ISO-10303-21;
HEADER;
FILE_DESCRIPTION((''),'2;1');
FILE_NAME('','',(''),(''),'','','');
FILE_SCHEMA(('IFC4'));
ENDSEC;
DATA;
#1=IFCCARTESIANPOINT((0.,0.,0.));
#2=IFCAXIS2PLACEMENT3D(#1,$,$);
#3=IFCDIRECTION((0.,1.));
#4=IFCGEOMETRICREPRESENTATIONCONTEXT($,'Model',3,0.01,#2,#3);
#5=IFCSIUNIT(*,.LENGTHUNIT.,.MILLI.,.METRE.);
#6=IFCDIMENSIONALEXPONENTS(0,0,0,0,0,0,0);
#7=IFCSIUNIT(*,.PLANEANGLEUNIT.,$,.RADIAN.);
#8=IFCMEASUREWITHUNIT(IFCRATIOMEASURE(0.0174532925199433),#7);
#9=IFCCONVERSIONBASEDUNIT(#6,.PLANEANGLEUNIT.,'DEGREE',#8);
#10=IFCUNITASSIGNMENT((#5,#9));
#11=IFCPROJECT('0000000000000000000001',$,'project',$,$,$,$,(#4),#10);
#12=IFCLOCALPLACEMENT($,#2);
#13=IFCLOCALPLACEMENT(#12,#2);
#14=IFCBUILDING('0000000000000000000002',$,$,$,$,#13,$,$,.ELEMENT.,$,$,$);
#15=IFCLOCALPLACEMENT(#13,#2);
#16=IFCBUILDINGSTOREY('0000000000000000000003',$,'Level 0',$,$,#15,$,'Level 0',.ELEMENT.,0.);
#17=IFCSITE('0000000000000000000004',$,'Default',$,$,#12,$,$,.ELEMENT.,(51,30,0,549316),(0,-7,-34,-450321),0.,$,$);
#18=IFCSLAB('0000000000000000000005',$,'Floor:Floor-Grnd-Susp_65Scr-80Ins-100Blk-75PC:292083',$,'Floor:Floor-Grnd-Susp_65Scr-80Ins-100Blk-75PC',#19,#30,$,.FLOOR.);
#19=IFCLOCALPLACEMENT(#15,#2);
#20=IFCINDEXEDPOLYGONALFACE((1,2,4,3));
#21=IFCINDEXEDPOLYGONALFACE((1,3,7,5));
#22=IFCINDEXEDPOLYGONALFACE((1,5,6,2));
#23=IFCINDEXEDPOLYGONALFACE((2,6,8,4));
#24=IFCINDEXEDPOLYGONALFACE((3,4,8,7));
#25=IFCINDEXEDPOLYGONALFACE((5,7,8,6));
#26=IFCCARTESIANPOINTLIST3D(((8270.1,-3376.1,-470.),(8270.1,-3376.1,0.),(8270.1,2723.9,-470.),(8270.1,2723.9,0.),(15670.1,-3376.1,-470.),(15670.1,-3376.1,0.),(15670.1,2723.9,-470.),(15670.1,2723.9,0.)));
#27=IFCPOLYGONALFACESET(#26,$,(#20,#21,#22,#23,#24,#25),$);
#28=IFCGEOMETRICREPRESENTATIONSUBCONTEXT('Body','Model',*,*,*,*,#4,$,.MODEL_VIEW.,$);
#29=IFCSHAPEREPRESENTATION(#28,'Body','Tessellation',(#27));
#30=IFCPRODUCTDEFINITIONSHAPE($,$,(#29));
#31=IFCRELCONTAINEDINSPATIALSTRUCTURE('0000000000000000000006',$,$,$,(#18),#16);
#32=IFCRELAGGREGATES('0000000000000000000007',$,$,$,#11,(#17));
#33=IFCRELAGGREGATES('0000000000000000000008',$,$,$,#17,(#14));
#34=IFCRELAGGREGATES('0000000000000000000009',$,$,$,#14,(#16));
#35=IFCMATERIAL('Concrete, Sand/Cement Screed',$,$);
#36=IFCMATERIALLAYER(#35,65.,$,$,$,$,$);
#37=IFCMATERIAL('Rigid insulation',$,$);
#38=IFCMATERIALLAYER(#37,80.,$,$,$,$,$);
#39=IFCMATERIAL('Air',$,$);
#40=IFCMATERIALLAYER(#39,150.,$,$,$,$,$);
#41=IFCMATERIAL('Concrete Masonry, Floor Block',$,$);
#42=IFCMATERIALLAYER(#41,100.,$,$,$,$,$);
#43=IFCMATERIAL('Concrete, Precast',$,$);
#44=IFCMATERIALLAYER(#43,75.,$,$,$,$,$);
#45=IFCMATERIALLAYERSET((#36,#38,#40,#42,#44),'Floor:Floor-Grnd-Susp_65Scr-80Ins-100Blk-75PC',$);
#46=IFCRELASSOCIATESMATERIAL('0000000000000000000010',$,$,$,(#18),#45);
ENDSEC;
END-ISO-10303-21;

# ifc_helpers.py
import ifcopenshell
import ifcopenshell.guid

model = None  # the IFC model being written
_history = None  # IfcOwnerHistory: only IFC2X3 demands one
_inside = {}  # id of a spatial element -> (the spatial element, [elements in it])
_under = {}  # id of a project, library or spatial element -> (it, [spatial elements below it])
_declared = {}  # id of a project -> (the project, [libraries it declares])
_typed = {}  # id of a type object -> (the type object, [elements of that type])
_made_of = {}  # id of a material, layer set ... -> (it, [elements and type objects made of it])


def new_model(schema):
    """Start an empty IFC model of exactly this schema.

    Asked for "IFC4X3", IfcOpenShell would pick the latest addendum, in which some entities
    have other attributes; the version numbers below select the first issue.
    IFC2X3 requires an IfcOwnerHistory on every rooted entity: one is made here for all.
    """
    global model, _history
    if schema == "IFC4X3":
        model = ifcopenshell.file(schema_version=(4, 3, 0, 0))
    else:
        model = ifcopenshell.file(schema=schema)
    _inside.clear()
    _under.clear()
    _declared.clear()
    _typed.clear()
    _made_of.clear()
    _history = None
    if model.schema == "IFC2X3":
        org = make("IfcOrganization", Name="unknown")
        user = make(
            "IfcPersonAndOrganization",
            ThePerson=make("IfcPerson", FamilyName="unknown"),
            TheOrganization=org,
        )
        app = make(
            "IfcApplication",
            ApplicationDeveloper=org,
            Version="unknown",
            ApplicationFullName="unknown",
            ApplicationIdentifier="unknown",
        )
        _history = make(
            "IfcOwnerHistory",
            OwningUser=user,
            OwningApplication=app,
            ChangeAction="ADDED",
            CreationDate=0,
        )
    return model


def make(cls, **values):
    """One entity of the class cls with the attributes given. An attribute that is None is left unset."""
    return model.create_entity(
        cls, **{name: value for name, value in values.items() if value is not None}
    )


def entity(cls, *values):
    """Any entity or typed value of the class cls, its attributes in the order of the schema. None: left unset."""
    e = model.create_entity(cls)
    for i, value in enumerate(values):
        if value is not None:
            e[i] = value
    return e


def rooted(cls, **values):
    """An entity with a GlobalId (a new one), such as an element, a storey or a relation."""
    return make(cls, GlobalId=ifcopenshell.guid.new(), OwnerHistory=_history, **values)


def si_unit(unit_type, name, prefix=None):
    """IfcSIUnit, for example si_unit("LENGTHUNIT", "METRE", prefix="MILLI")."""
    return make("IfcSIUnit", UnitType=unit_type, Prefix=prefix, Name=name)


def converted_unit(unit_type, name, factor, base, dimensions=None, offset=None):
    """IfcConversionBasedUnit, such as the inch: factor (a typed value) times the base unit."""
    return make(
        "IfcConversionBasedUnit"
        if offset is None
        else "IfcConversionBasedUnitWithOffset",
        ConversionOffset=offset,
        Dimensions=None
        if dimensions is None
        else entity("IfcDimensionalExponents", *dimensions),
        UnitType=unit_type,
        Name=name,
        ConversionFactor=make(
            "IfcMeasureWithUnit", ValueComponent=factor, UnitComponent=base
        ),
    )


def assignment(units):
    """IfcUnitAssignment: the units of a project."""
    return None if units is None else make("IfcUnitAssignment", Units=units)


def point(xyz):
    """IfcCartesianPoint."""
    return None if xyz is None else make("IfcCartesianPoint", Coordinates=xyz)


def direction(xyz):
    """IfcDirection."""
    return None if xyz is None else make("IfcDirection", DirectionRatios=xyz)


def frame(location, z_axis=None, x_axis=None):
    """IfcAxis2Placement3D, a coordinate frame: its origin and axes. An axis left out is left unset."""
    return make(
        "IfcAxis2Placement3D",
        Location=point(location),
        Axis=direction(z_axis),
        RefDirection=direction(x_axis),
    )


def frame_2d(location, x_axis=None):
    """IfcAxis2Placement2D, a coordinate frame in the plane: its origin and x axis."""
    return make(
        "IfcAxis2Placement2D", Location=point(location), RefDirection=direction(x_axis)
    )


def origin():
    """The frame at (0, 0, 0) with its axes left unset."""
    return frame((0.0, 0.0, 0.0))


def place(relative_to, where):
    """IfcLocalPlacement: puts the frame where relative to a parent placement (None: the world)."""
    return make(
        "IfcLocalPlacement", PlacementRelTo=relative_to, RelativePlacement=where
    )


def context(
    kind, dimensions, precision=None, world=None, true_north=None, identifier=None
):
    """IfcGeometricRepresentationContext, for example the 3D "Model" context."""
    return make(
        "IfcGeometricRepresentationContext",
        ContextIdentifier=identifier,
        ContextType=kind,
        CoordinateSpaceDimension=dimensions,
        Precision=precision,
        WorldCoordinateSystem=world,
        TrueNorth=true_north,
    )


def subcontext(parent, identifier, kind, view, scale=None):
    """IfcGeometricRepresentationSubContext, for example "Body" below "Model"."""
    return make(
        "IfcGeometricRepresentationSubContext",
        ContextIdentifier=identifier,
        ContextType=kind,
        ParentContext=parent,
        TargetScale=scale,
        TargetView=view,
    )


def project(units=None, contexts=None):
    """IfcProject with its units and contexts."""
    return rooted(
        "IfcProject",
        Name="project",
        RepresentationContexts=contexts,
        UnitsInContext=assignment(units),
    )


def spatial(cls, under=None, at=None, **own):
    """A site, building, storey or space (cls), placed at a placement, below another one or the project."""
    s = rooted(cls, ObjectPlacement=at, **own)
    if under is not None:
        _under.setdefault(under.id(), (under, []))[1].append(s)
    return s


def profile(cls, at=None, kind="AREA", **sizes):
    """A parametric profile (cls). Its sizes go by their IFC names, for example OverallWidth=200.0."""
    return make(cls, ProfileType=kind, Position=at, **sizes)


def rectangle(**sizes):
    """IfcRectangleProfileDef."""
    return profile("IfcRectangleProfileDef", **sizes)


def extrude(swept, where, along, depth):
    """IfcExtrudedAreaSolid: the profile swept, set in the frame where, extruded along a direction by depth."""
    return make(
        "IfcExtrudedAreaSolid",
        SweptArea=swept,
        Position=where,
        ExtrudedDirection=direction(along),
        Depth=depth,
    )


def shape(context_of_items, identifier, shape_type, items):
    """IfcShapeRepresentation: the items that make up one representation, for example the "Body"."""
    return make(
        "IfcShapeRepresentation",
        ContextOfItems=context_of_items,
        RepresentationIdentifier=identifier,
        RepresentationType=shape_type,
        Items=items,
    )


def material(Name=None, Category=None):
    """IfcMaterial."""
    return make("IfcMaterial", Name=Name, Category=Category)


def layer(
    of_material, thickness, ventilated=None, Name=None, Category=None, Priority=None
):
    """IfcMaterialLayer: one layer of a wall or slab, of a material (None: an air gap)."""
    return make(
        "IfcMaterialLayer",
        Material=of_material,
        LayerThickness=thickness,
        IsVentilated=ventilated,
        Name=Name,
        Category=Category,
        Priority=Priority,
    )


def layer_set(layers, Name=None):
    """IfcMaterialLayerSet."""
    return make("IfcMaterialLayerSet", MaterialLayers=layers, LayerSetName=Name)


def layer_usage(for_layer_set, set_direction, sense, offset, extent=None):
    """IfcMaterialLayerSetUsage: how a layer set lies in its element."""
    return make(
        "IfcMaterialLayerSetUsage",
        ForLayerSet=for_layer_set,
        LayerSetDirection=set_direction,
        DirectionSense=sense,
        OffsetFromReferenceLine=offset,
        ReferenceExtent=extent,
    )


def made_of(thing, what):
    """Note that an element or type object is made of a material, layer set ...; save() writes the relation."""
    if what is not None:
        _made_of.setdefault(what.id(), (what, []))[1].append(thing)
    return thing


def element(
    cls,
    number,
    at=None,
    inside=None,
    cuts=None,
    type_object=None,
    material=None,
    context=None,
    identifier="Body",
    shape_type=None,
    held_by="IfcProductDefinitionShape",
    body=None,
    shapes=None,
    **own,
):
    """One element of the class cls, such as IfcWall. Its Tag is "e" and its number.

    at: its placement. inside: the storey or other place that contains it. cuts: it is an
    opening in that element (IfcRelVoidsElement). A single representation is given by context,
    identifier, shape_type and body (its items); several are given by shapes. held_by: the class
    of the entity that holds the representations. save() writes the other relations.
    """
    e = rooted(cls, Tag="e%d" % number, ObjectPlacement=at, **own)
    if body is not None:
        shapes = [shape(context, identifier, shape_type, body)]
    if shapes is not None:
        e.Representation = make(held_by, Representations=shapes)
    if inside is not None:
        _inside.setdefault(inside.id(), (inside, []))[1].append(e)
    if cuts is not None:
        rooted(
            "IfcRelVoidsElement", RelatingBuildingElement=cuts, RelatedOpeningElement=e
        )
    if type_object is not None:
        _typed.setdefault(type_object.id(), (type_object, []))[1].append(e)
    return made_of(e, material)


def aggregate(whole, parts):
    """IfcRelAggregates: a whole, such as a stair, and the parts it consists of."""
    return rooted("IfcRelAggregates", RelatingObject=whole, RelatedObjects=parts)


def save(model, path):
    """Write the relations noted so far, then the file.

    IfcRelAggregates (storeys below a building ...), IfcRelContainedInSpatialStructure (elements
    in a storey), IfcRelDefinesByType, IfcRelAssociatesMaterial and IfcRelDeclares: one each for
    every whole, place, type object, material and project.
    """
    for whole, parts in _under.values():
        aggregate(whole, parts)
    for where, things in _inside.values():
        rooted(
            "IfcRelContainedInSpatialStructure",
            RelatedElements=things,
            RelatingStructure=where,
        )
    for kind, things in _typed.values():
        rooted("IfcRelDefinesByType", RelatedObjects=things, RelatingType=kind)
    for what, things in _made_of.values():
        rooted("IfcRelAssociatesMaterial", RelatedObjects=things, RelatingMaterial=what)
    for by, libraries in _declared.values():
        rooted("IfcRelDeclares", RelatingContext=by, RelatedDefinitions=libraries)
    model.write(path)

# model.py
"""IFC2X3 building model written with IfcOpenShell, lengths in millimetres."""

from ifc_helpers import new_model, entity, si_unit, converted_unit, direction, frame, frame_2d, origin, place, context, subcontext, project, spatial, rectangle, extrude, material, layer, layer_set, layer_usage, element, save


model = new_model("IFC2X3")

# Units and contexts
model_context = context("Model", 3, precision=0.01, world=origin(), true_north=direction((0.0, 1.0)))
body_context = subcontext(model_context, "Body", "Model", "MODEL_VIEW")
ifc_project = project(units=[si_unit("LENGTHUNIT", "METRE", prefix="MILLI"), converted_unit("PLANEANGLEUNIT", "DEGREE", entity("IfcRatioMeasure", 0.0174532925199433), si_unit("PLANEANGLEUNIT", "RADIAN"), dimensions=[0, 0, 0, 0, 0, 0, 0])], contexts=[model_context])

# Site, building, storey
site_placement = place(None, origin())
site = spatial("IfcSite", under=ifc_project, at=site_placement, Name="Default", CompositionType="ELEMENT", RefLatitude=(51, 30, 0, 549316), RefLongitude=(0, -7, -34, -450321), RefElevation=0.0)
building_placement = place(site_placement, origin())
building = spatial("IfcBuilding", under=site, at=building_placement, CompositionType="ELEMENT")
storey_placement = place(building_placement, origin())
storey = spatial("IfcBuildingStorey", under=building, at=storey_placement, Name="Level 0", LongName="Level 0", CompositionType="ELEMENT", Elevation=0.0)

# Slab
ifc_material_1 = material(Name="Concrete, Sand/Cement Screed")
ifc_layer_1 = layer(ifc_material_1, 65.0)
ifc_material_2 = material(Name="Rigid insulation")
ifc_layer_2 = layer(ifc_material_2, 80.0)
ifc_material_3 = material(Name="Air")
ifc_layer_3 = layer(ifc_material_3, 150.0)
ifc_material_4 = material(Name="Concrete Masonry, Floor Block")
ifc_layer_4 = layer(ifc_material_4, 100.0)
ifc_material_5 = material(Name="Concrete, Precast")
ifc_layer_5 = layer(ifc_material_5, 75.0)
ifc_layer_set = layer_set([ifc_layer_1, ifc_layer_2, ifc_layer_3, ifc_layer_4, ifc_layer_5], Name="Floor:Floor-Grnd-Susp_65Scr-80Ins-100Blk-75PC")
ifc_layer_usage = layer_usage(ifc_layer_set, "AXIS3", "POSITIVE", 0.0)
slab_placement = place(storey_placement, origin())
element("IfcSlab", 1, at=slab_placement, inside=storey, material=ifc_layer_usage, Name="Floor:Floor-Grnd-Susp_65Scr-80Ins-100Blk-75PC:292083", ObjectType="Floor:Floor-Grnd-Susp_65Scr-80Ins-100Blk-75PC", PredefinedType="FLOOR", context=body_context, shape_type="SweptSolid", body=[
    extrude(rectangle(XDim=6100.0, YDim=7400.0, at=frame_2d((0.0, 0.0), x_axis=(1.0, 0.0))), frame((11970.1, -326.1, 0.0), z_axis=(0.0, 0.0, -1.0), x_axis=(0.0, 1.0, 0.0)), (0.0, 0.0, 1.0), 470.0),
])

save(model, "model.ifc")
